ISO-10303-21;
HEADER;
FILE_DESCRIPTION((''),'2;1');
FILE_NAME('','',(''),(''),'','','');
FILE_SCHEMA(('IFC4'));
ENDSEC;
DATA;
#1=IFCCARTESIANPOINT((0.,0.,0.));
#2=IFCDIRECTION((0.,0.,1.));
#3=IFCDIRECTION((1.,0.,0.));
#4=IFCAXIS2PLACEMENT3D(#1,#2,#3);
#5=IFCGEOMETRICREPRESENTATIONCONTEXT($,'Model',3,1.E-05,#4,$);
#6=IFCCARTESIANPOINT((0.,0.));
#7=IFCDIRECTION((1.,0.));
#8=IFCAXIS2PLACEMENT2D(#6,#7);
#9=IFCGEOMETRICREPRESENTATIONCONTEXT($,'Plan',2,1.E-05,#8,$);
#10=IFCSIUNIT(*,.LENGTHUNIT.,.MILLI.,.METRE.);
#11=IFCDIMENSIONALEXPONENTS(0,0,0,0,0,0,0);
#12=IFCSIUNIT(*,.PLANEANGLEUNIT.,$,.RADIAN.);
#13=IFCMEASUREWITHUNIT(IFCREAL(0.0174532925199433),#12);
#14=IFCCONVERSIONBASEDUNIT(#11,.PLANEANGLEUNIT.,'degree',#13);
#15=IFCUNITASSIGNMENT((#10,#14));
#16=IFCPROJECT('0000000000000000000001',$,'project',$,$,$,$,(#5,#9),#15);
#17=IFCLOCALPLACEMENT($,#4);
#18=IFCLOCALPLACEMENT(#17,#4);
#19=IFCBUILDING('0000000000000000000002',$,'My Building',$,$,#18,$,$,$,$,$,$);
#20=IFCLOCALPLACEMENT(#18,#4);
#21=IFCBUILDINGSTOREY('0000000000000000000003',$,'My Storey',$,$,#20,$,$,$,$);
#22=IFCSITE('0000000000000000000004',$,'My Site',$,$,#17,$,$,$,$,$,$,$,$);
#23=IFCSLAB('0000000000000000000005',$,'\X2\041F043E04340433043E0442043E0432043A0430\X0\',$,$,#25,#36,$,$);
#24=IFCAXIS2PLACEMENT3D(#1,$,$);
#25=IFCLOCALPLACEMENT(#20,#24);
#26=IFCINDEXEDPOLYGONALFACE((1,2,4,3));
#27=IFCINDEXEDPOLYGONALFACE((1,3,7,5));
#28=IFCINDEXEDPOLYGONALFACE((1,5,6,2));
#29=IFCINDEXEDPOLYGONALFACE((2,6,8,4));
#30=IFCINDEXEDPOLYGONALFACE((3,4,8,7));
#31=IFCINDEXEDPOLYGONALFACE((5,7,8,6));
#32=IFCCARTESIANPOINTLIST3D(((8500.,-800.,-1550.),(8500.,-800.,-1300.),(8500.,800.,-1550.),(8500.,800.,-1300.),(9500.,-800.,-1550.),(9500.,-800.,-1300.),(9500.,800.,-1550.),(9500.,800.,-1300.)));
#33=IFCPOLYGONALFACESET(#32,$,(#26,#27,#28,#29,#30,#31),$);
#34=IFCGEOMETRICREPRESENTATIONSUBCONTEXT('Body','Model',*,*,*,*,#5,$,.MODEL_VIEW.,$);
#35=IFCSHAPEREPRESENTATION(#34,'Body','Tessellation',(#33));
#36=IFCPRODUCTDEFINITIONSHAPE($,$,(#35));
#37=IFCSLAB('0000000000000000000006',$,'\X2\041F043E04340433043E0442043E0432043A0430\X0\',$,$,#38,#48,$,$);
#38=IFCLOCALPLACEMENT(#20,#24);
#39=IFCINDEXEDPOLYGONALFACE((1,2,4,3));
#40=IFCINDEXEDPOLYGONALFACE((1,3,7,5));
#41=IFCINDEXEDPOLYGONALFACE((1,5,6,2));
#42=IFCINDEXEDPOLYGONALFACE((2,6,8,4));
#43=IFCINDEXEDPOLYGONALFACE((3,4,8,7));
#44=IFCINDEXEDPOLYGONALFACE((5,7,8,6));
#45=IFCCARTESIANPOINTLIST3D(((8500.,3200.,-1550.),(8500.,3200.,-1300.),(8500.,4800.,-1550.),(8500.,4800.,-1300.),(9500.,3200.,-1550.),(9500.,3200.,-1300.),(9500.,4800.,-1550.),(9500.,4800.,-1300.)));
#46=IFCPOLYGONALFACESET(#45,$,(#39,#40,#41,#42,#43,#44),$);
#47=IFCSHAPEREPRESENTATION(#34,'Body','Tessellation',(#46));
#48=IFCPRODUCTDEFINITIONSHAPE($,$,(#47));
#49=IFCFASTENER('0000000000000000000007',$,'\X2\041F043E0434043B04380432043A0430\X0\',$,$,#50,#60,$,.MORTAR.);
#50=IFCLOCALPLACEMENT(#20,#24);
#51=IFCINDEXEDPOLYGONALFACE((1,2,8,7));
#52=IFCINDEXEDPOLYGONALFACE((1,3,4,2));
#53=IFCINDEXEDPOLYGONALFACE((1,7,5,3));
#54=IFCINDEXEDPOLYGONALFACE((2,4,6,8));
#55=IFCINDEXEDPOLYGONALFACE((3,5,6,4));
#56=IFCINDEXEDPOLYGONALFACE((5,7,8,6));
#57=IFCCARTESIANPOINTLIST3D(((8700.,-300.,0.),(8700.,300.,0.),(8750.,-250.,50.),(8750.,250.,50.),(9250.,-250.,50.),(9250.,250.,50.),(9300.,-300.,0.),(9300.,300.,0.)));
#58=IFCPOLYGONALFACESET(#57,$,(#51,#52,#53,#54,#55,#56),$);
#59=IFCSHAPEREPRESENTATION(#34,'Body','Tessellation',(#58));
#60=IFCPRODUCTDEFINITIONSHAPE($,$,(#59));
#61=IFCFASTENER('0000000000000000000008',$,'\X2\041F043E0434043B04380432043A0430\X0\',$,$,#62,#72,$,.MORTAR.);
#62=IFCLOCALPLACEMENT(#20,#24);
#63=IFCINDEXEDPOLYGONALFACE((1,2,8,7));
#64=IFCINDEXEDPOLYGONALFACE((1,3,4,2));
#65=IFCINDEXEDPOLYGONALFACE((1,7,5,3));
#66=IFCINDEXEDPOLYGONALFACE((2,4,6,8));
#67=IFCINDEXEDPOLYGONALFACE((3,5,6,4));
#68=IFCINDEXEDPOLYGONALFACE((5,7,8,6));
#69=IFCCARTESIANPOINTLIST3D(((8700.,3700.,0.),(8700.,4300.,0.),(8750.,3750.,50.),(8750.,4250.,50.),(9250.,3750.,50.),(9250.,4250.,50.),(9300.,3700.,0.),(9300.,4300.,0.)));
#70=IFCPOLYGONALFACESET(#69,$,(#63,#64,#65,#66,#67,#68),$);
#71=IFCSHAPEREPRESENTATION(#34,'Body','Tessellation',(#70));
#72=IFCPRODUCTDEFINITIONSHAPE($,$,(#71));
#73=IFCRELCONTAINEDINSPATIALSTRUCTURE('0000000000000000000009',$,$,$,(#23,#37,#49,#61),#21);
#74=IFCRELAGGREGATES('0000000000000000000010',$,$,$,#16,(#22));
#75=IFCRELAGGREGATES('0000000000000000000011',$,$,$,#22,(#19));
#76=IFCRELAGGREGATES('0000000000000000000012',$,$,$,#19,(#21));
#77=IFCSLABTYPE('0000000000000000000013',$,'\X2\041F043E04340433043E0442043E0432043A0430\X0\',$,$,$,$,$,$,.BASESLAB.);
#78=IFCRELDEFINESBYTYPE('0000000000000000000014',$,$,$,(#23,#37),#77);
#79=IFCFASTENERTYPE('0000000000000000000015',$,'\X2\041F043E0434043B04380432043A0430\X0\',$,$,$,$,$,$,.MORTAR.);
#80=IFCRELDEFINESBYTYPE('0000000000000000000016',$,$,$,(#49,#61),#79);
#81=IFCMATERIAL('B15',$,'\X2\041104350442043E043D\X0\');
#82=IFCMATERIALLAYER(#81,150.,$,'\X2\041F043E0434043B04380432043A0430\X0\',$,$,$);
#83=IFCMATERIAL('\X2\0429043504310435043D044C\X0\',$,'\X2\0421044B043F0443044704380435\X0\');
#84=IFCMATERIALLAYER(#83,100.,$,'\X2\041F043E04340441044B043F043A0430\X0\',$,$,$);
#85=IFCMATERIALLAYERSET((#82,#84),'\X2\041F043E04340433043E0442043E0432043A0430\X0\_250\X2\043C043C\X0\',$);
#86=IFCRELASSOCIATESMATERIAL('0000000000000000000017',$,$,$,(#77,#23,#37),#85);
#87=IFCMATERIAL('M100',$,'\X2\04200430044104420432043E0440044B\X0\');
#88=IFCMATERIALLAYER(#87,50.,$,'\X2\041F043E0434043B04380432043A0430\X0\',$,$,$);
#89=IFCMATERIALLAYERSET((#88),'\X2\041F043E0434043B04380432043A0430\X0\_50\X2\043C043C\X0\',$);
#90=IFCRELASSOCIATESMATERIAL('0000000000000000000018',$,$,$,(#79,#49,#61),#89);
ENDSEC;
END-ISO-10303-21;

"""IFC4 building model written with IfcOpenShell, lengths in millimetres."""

from ifc_helpers import new_model, entity, si_unit, converted_unit, frame, origin_with_axes, origin_2d_with_axis, place, context, subcontext, project, spatial, line, indexed_curve, outline, extrude, clip, halfspace, material, layer, layer_set, layer_usage, type_object, element, save


model = new_model("IFC4")

# Units and contexts
model_context = context("Model", 3, precision=1e-05, world=origin_with_axes())
plan_context = context("Plan", 2, precision=1e-05, world=origin_2d_with_axis())
body_context = subcontext(model_context, "Body", "Model", "MODEL_VIEW")
ifc_project = project(units=[si_unit("LENGTHUNIT", "METRE", prefix="MILLI"), converted_unit("PLANEANGLEUNIT", "degree", entity("IfcReal", 0.0174532925199433), si_unit("PLANEANGLEUNIT", "RADIAN"), dimensions=[0, 0, 0, 0, 0, 0, 0])], contexts=[model_context, plan_context])

# Site, building, storey
site_placement = place(None, origin_with_axes())
site = spatial("IfcSite", under=ifc_project, at=site_placement, Name="My Site")
building_placement = place(site_placement, origin_with_axes())
building = spatial("IfcBuilding", under=site, at=building_placement, Name="My Building")
storey_placement = place(building_placement, origin_with_axes())
storey = spatial("IfcBuildingStorey", under=building, at=storey_placement, Name="My Storey")

# Slabs
ifc_material_1 = material(Name="B15", Category="Бетон")
ifc_layer_1 = layer(ifc_material_1, 150.0, Name="Подливка")
ifc_material_2 = material(Name="Щебень", Category="Сыпучие")
ifc_layer_2 = layer(ifc_material_2, 100.0, Name="Подсыпка")
ifc_layer_set_1 = layer_set([ifc_layer_1, ifc_layer_2], Name="Подготовка_250мм")
ifc_layer_usage_1 = layer_usage(ifc_layer_set_1, "AXIS3", "NEGATIVE", 0.0)
slab_type = type_object("IfcSlabType", Name="Подготовка", PredefinedType="BASESLAB", material=ifc_layer_set_1)
slab_1_placement = place(storey_placement, frame((9000.0, 0.0, -1550.0), z_axis=(0.0, 0.0, 1.0), x_axis=(1.0, 0.0, 0.0)))
element("IfcSlab", 1, at=slab_1_placement, inside=storey, type_object=slab_type, material=ifc_layer_usage_1, Name="Подготовка", context=body_context, shape_type="SweptSolid", body=[
    extrude(outline(indexed_curve([(500.0, 800.0), (500.0, -800.0), (-500.0, -800.0), (-500.0, 800.0)], segments=[line(3, 2), line(2, 1), line(1, 4), line(4, 3)], self_intersect=False)), None, (0.0, 0.0, 1.0), 250.0),
])
slab_2_placement = place(storey_placement, frame((9000.0, 4000.0, -1550.0), z_axis=(0.0, 0.0, 1.0), x_axis=(1.0, 0.0, 0.0)))
element("IfcSlab", 2, at=slab_2_placement, inside=storey, type_object=slab_type, material=ifc_layer_usage_1, Name="Подготовка", context=body_context, shape_type="SweptSolid", body=[
    extrude(outline(indexed_curve([(-500.0, -800.0), (500.0, -800.0), (500.0, 800.0), (-500.0, 800.0)], segments=[line(3, 2), line(2, 1), line(1, 4), line(4, 3)], self_intersect=False)), None, (0.0, 0.0, 1.0), 250.0),
])

# Fasteners
ifc_material_3 = material(Name="M100", Category="Растворы")
ifc_layer_3 = layer(ifc_material_3, 50.0, Name="Подливка")
ifc_layer_set_2 = layer_set([ifc_layer_3], Name="Подливка_50мм")
ifc_layer_usage_2 = layer_usage(ifc_layer_set_2, "AXIS3", "POSITIVE", 0.0)
fastener_type = type_object("IfcFastenerType", Name="Подливка", PredefinedType="MORTAR", material=ifc_layer_set_2)
fastener_1_placement = place(storey_placement, frame((9000.0, 0.0, 0.0), z_axis=(0.0, 0.0, 1.0), x_axis=(1.0, 0.0, 0.0)))
element("IfcFastener", 3, at=fastener_1_placement, inside=storey, type_object=fastener_type, material=ifc_layer_usage_2, Name="Подливка", PredefinedType="MORTAR", context=body_context, shape_type="Clipping", body=[
    clip(clip(clip(clip(extrude(outline(indexed_curve([(-300.0, -300.0), (300.0, -300.0), (300.0, 300.0), (-300.0, 300.0)], segments=[line(3, 2), line(2, 1), line(1, 4), line(4, 3)], self_intersect=False)), None, (0.0, 0.0, 1.0), 50.0), halfspace(frame((-53.6, 200.0, 353.6), z_axis=(0.707107, 0.0, 0.707107), x_axis=(0.707107, 0.0, -0.707107)), False)), halfspace(frame((-200.0, -53.6, 353.6), z_axis=(0.0, 0.707107, 0.707107), x_axis=(0.0, 0.707107, -0.707107)), False)), halfspace(frame((200.0, 53.6, 353.6), z_axis=(0.0, -0.707107, 0.707107), x_axis=(0.0, -0.707107, -0.707107)), False)), halfspace(frame((53.6, 200.0, 353.6), z_axis=(-0.707107, 0.0, 0.707107), x_axis=(-0.707107, 0.0, -0.707107)), False)),
])
fastener_2_placement = place(storey_placement, frame((9000.0, 4000.0, 0.0), z_axis=(0.0, 0.0, 1.0), x_axis=(1.0, 0.0, 0.0)))
element("IfcFastener", 4, at=fastener_2_placement, inside=storey, type_object=fastener_type, material=ifc_layer_usage_2, Name="Подливка", PredefinedType="MORTAR", context=body_context, shape_type="Clipping", body=[
    clip(clip(clip(clip(extrude(outline(indexed_curve([(-300.0, -300.0), (300.0, -300.0), (300.0, 300.0), (-300.0, 300.0)], segments=[line(3, 2), line(2, 1), line(1, 4), line(4, 3)], self_intersect=False)), None, (0.0, 0.0, 1.0), 50.0), halfspace(frame((-53.6, 200.0, 353.6), z_axis=(0.707107, 0.0, 0.707107), x_axis=(0.707107, 0.0, -0.707107)), False)), halfspace(frame((-200.0, -53.6, 353.6), z_axis=(0.0, 0.707107, 0.707107), x_axis=(0.0, 0.707107, -0.707107)), False)), halfspace(frame((200.0, 53.6, 353.6), z_axis=(0.0, -0.707107, 0.707107), x_axis=(0.0, -0.707107, -0.707107)), False)), halfspace(frame((53.6, 200.0, 353.6), z_axis=(-0.707107, 0.0, 0.707107), x_axis=(-0.707107, 0.0, -0.707107)), False)),
])

save(model, "model.ifc")
